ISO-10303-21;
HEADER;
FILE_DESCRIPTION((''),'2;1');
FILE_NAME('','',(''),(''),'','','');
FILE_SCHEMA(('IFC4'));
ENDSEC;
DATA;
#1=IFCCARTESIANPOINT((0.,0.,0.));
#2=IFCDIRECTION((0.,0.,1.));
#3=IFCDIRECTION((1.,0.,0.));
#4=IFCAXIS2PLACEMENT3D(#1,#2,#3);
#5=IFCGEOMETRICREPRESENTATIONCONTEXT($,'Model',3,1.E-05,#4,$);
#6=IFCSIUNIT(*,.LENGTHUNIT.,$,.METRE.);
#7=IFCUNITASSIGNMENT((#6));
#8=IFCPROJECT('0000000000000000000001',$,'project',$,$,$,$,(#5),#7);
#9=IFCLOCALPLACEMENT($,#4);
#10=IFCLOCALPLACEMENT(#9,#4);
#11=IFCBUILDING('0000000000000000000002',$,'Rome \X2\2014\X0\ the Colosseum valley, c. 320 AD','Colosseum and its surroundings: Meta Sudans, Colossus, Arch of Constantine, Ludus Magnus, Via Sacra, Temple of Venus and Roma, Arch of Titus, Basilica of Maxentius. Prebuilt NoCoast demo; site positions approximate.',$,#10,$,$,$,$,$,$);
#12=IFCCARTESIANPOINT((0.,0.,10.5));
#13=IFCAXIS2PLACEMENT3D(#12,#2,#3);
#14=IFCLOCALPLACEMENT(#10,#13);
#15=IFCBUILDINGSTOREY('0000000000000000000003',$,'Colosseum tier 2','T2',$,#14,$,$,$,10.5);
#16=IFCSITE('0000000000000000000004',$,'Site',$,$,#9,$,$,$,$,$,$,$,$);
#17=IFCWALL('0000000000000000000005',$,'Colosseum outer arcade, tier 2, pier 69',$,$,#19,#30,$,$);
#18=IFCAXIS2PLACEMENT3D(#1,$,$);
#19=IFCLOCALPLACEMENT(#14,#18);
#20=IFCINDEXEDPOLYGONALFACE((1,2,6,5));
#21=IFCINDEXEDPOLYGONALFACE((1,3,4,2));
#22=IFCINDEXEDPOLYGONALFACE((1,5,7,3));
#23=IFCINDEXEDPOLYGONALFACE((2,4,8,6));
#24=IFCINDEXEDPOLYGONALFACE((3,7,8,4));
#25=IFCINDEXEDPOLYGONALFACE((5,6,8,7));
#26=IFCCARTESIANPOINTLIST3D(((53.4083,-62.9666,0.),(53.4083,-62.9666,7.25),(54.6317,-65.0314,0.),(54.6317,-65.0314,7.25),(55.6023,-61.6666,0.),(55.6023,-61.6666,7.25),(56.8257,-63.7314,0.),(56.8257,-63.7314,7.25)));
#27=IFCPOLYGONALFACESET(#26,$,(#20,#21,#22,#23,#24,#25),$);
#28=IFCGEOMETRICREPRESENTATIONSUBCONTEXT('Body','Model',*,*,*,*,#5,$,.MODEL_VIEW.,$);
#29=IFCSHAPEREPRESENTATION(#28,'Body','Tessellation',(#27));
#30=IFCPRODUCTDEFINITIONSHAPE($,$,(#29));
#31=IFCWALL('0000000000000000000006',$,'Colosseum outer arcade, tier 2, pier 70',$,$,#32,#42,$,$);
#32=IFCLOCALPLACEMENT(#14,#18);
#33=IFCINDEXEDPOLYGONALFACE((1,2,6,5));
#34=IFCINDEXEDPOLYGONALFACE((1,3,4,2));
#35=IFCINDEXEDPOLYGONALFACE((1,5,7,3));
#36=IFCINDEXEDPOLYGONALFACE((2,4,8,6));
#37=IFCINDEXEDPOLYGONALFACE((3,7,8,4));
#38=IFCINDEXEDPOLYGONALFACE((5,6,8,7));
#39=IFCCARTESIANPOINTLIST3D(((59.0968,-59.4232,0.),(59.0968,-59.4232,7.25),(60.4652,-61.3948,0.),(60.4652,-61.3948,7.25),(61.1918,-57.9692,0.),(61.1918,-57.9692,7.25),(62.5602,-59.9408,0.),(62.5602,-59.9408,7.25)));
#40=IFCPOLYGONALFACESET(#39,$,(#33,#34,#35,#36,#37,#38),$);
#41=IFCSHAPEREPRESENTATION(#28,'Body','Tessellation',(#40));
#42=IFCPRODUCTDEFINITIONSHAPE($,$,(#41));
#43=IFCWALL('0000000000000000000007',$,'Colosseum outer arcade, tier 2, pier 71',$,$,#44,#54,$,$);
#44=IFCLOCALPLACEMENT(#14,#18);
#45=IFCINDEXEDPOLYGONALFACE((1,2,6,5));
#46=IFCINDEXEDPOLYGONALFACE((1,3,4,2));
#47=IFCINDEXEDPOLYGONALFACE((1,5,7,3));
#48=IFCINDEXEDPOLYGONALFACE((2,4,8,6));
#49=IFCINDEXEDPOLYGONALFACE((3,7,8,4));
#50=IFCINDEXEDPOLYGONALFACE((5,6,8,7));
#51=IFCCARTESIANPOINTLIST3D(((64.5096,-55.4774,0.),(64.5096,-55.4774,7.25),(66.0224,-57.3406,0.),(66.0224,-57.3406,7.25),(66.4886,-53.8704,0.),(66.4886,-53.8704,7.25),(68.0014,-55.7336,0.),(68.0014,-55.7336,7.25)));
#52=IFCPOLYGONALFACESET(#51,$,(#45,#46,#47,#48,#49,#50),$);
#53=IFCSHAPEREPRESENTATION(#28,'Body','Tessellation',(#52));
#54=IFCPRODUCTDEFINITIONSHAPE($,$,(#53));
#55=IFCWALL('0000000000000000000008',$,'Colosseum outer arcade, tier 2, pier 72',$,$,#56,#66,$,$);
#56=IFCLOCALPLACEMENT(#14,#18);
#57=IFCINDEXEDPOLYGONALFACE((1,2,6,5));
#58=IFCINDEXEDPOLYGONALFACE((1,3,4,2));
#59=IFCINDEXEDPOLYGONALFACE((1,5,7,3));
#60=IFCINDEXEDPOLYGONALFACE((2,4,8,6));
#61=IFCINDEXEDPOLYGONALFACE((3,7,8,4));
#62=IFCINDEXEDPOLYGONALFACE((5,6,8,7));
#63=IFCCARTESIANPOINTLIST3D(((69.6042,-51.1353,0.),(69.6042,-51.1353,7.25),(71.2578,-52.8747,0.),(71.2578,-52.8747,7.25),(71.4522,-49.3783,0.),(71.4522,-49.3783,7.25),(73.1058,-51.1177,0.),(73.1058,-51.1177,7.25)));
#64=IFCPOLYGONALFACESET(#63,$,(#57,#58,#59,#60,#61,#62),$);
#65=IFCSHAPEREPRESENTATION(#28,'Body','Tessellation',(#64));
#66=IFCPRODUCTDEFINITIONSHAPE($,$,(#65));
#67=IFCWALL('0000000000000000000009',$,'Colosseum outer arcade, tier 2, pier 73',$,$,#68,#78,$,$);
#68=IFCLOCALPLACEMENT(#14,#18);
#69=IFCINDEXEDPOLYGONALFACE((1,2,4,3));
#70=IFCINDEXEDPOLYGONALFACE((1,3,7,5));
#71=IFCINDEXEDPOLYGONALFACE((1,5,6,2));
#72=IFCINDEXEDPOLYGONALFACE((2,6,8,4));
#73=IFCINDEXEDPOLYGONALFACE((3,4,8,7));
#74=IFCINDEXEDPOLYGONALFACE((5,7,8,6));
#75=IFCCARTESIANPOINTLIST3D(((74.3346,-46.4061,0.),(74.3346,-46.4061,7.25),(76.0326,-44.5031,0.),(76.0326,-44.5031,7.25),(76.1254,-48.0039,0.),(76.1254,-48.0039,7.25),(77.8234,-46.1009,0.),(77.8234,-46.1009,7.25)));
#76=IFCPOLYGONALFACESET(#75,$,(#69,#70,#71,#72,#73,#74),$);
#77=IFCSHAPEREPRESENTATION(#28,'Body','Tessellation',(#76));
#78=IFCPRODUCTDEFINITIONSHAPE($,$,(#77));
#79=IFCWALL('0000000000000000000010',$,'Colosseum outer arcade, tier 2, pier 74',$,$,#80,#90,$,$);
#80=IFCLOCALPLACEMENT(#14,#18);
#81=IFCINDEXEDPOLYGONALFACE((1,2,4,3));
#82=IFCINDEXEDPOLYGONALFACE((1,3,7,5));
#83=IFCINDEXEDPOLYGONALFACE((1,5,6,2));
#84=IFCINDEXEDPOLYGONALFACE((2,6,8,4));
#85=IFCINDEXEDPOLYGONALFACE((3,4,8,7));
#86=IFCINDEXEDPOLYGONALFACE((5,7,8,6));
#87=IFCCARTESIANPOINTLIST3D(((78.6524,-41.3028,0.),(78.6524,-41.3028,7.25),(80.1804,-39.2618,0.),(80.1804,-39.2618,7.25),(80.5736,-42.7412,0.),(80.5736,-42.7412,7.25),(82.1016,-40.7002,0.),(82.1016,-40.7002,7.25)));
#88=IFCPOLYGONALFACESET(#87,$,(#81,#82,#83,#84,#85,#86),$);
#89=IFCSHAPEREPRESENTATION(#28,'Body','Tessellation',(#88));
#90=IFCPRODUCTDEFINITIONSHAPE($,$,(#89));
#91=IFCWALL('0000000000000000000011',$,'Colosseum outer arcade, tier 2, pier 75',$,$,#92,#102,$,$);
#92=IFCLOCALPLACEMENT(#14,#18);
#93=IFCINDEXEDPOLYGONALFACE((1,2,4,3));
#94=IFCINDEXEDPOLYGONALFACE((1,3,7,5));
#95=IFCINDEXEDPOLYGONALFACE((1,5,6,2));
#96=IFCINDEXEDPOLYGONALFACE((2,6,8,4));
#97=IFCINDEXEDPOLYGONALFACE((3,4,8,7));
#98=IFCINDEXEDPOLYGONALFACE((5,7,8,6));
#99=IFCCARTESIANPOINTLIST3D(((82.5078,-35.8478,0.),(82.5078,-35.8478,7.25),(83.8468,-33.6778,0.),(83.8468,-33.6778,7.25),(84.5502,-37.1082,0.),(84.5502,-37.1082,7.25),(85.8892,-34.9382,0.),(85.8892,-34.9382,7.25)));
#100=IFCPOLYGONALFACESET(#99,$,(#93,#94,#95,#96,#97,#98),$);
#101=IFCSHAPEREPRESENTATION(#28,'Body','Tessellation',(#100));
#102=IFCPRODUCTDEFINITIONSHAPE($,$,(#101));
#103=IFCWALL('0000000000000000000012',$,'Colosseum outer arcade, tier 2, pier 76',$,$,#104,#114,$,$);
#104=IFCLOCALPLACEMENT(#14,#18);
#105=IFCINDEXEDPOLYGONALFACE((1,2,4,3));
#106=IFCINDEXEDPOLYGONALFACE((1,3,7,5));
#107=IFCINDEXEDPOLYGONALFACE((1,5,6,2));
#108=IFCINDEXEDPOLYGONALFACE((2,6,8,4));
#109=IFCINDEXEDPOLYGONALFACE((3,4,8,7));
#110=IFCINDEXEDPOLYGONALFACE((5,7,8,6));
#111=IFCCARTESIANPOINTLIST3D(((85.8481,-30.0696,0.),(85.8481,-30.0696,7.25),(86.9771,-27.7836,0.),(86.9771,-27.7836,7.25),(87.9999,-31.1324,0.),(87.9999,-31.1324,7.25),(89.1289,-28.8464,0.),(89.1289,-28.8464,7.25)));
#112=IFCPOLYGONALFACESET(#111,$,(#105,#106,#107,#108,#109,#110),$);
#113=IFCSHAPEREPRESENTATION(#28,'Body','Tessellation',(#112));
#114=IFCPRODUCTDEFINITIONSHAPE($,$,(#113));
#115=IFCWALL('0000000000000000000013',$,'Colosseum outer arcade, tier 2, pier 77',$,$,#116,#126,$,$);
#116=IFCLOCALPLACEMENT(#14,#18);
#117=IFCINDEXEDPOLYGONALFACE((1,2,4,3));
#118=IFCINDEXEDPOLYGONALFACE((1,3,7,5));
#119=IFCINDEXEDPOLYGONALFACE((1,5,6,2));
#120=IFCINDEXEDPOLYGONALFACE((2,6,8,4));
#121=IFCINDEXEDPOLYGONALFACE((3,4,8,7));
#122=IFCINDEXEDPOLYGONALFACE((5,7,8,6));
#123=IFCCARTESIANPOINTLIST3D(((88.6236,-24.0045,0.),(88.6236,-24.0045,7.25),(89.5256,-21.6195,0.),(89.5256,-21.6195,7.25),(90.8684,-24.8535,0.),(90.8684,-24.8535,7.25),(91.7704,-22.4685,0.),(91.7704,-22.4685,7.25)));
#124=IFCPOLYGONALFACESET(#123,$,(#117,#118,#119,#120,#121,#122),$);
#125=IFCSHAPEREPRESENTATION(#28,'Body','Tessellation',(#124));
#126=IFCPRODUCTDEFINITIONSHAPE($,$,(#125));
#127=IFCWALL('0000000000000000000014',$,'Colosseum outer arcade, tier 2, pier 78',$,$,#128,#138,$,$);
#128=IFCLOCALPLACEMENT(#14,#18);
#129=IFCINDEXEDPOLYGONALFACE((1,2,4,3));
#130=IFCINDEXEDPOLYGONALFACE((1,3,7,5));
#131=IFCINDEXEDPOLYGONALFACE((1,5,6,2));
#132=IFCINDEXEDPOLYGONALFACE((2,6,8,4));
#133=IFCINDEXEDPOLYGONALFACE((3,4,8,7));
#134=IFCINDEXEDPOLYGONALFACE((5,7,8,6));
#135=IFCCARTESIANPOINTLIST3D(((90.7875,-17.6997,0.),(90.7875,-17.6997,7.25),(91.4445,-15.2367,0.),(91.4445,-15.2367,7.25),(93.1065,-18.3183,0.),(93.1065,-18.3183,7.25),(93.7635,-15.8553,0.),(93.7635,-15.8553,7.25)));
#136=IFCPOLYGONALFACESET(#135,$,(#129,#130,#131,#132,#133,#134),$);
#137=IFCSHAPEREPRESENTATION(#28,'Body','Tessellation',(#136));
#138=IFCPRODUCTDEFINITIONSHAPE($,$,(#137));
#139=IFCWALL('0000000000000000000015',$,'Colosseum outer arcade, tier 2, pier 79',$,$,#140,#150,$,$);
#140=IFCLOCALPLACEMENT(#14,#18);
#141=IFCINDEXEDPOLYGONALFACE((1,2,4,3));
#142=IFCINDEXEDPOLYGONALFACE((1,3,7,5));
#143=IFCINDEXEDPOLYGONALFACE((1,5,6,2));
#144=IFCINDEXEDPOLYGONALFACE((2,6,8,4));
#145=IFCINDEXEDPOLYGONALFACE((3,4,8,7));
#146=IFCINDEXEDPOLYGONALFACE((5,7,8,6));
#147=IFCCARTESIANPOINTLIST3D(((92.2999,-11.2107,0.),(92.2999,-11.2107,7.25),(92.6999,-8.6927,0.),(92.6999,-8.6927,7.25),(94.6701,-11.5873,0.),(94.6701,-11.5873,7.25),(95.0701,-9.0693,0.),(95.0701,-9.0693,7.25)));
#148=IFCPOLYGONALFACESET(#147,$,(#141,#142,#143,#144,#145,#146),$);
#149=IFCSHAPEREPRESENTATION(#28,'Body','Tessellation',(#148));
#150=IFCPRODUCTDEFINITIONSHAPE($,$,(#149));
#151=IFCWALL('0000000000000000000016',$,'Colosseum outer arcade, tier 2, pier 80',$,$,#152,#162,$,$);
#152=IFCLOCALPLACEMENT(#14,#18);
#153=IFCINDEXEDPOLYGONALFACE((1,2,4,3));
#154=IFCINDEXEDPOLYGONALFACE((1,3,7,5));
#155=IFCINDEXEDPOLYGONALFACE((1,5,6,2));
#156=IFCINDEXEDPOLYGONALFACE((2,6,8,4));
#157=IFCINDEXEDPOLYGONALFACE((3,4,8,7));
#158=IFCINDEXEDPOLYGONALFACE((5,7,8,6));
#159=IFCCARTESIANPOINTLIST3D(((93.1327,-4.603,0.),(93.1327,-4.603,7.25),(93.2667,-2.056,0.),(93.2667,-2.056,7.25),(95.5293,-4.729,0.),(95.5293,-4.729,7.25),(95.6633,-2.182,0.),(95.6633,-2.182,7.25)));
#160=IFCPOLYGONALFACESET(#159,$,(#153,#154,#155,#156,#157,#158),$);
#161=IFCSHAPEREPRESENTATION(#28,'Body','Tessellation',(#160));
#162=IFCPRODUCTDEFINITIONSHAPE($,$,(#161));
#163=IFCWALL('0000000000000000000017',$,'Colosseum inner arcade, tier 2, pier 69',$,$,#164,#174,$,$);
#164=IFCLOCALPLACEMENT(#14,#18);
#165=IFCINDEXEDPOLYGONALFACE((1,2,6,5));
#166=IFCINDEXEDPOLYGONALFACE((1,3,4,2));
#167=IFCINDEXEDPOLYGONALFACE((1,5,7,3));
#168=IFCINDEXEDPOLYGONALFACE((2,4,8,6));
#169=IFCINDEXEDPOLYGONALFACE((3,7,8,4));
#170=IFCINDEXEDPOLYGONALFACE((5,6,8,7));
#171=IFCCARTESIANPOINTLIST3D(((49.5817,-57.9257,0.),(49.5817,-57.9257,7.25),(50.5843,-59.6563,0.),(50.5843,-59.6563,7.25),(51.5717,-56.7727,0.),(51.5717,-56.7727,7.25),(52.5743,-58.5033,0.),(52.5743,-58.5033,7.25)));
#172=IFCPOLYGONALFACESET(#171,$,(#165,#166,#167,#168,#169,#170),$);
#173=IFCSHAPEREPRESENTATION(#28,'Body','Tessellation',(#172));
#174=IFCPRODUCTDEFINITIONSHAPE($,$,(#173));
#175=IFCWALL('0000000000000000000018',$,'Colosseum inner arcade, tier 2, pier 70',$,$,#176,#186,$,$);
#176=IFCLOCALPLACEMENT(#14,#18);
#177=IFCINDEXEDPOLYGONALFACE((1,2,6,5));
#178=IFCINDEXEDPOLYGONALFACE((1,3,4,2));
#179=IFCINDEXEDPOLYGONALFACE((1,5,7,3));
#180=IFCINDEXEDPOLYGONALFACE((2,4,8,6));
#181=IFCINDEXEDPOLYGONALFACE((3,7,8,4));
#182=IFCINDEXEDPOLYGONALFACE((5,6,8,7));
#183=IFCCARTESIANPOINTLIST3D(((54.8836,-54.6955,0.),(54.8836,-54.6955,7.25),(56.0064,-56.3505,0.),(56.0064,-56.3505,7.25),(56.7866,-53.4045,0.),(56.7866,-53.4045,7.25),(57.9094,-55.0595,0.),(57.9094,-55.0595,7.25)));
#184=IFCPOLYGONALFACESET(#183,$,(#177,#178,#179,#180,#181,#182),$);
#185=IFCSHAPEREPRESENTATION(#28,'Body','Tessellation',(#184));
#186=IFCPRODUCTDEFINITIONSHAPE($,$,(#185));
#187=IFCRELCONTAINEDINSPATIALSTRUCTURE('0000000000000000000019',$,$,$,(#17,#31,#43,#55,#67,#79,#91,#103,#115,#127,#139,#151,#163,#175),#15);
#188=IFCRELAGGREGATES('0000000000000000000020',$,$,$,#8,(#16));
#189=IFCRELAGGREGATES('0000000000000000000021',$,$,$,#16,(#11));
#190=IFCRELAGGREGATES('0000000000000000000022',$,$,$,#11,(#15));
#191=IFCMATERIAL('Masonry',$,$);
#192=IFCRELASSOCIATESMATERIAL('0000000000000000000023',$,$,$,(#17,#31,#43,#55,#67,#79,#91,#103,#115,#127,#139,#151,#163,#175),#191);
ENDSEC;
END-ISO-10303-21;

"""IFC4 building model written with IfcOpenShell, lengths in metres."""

from ifc_helpers import new_model, si_unit, frame, origin_with_axes, place, context, subcontext, project, spatial, indexed_curve, outline, extrude, material, element, save


model = new_model("IFC4")

# Units and contexts
model_context = context("Model", 3, precision=1e-05, world=origin_with_axes())
body_context = subcontext(model_context, "Body", "Model", "MODEL_VIEW")
ifc_project = project(units=[si_unit("LENGTHUNIT", "METRE")], contexts=[model_context])

# Site, building, storey
site_placement = place(None, origin_with_axes())
site = spatial("IfcSite", under=ifc_project, at=site_placement, Name="Site")
building_placement = place(site_placement, origin_with_axes())
building = spatial("IfcBuilding", under=site, at=building_placement, Name="Rome — the Colosseum valley, c. 320 AD", Description="Colosseum and its surroundings: Meta Sudans, Colossus, Arch of Constantine, Ludus Magnus, Via Sacra, Temple of Venus and Roma, Arch of Titus, Basilica of Maxentius. Prebuilt NoCoast demo; site positions approximate.")
storey_placement = place(building_placement, frame((0.0, 0.0, 10.5), z_axis=(0.0, 0.0, 1.0), x_axis=(1.0, 0.0, 0.0)))
storey = spatial("IfcBuildingStorey", under=building, at=storey_placement, Name="Colosseum tier 2", Description="T2", Elevation=10.5)

# Walls
ifc_material = material(Name="Masonry")
wall_1_placement = place(storey_placement, frame((54.02, -63.999, 0.0), z_axis=(0.0, 0.0, 1.0), x_axis=(0.860317, 0.509759, 0.0)))
element("IfcWall", 1, at=wall_1_placement, inside=storey, material=ifc_material, Name="Colosseum outer arcade, tier 2, pier 69", context=body_context, shape_type="SweptSolid", body=[
    extrude(outline(indexed_curve([(0.0, 0.0), (0.0, 2.4), (2.5502, 2.4), (2.5502, 0.0), (0.0, 0.0)], self_intersect=False)), frame((0.0, -1.2, 0.0), z_axis=(0.0, 0.0, 1.0), x_axis=(1.0, 0.0, 0.0)), (0.0, 0.0, 1.0), 7.25),
])
wall_2_placement = place(storey_placement, frame((59.781, -60.409, 0.0), z_axis=(0.0, 0.0, 1.0), x_axis=(0.821528, 0.570168, 0.0)))
element("IfcWall", 2, at=wall_2_placement, inside=storey, material=ifc_material, Name="Colosseum outer arcade, tier 2, pier 70", context=body_context, shape_type="SweptSolid", body=[
    extrude(outline(indexed_curve([(0.0, 0.0), (0.0, 2.4), (2.5501, 2.4), (2.5501, 0.0), (0.0, 0.0)], self_intersect=False)), frame((0.0, -1.2, 0.0), z_axis=(0.0, 0.0, 1.0), x_axis=(1.0, 0.0, 0.0)), (0.0, 0.0, 1.0), 7.25),
])
wall_3_placement = place(storey_placement, frame((65.266, -56.409, 0.0), z_axis=(0.0, 0.0, 1.0), x_axis=(0.776294, 0.630371, 0.0)))
element("IfcWall", 3, at=wall_3_placement, inside=storey, material=ifc_material, Name="Colosseum outer arcade, tier 2, pier 71", context=body_context, shape_type="SweptSolid", body=[
    extrude(outline(indexed_curve([(0.0, 0.0), (0.0, 2.4), (2.5493, 2.4), (2.5493, 0.0), (0.0, 0.0)], self_intersect=False)), frame((0.0, -1.2, 0.0), z_axis=(0.0, 0.0, 1.0), x_axis=(1.0, 0.0, 0.0)), (0.0, 0.0, 1.0), 7.25),
])
wall_4_placement = place(storey_placement, frame((70.431, -52.005, 0.0), z_axis=(0.0, 0.0, 1.0), x_axis=(0.724725, 0.689038, 0.0)))
element("IfcWall", 4, at=wall_4_placement, inside=storey, material=ifc_material, Name="Colosseum outer arcade, tier 2, pier 72", context=body_context, shape_type="SweptSolid", body=[
    extrude(outline(indexed_curve([(0.0, 0.0), (0.0, 2.4), (2.5499, 2.4), (2.5499, 0.0), (0.0, 0.0)], self_intersect=False)), frame((0.0, -1.2, 0.0), z_axis=(0.0, 0.0, 1.0), x_axis=(1.0, 0.0, 0.0)), (0.0, 0.0, 1.0), 7.25),
])
wall_5_placement = place(storey_placement, frame((75.23, -47.205, 0.0), z_axis=(0.0, 0.0, 1.0), x_axis=(0.665774, 0.746153, 0.0)))
element("IfcWall", 5, at=wall_5_placement, inside=storey, material=ifc_material, Name="Colosseum outer arcade, tier 2, pier 73", context=body_context, shape_type="SweptSolid", body=[
    extrude(outline(indexed_curve([(0.0, 0.0), (0.0, 2.4), (2.5504, 2.4), (2.5504, 0.0), (0.0, 0.0)], self_intersect=False)), frame((0.0, -1.2, 0.0), z_axis=(0.0, 0.0, 1.0), x_axis=(1.0, 0.0, 0.0)), (0.0, 0.0, 1.0), 7.25),
])
wall_6_placement = place(storey_placement, frame((79.613, -42.022, 0.0), z_axis=(0.0, 0.0, 1.0), x_axis=(0.599309, 0.800517, 0.0)))
element("IfcWall", 6, at=wall_6_placement, inside=storey, material=ifc_material, Name="Colosseum outer arcade, tier 2, pier 74", context=body_context, shape_type="SweptSolid", body=[
    extrude(outline(indexed_curve([(0.0, 0.0), (0.0, 2.4), (2.5496, 2.4), (2.5496, 0.0), (0.0, 0.0)], self_intersect=False)), frame((0.0, -1.2, 0.0), z_axis=(0.0, 0.0, 1.0), x_axis=(1.0, 0.0, 0.0)), (0.0, 0.0, 1.0), 7.25),
])
wall_7_placement = place(storey_placement, frame((83.529, -36.478, 0.0), z_axis=(0.0, 0.0, 1.0), x_axis=(0.525125, 0.851025, 0.0)))
element("IfcWall", 7, at=wall_7_placement, inside=storey, material=ifc_material, Name="Colosseum outer arcade, tier 2, pier 75", context=body_context, shape_type="SweptSolid", body=[
    extrude(outline(indexed_curve([(0.0, 0.0), (0.0, 2.4), (2.5499, 2.4), (2.5499, 0.0), (0.0, 0.0)], self_intersect=False)), frame((0.0, -1.2, 0.0), z_axis=(0.0, 0.0, 1.0), x_axis=(1.0, 0.0, 0.0)), (0.0, 0.0, 1.0), 7.25),
])
wall_8_placement = place(storey_placement, frame((86.924, -30.601, 0.0), z_axis=(0.0, 0.0, 1.0), x_axis=(0.442815, 0.896613, 0.0)))
element("IfcWall", 8, at=wall_8_placement, inside=storey, material=ifc_material, Name="Colosseum outer arcade, tier 2, pier 76", context=body_context, shape_type="SweptSolid", body=[
    extrude(outline(indexed_curve([(0.0, 0.0), (0.0, 2.4), (2.5496, 2.4), (2.5496, 0.0), (0.0, 0.0)], self_intersect=False)), frame((0.0, -1.2, 0.0), z_axis=(0.0, 0.0, 1.0), x_axis=(1.0, 0.0, 0.0)), (0.0, 0.0, 1.0), 7.25),
])
wall_9_placement = place(storey_placement, frame((89.746, -24.429, 0.0), z_axis=(0.0, 0.0, 1.0), x_axis=(0.353744, 0.935342, 0.0)))
element("IfcWall", 9, at=wall_9_placement, inside=storey, material=ifc_material, Name="Colosseum outer arcade, tier 2, pier 77", context=body_context, shape_type="SweptSolid", body=[
    extrude(outline(indexed_curve([(0.0, 0.0), (0.0, 2.4), (2.5499, 2.4), (2.5499, 0.0), (0.0, 0.0)], self_intersect=False)), frame((0.0, -1.2, 0.0), z_axis=(0.0, 0.0, 1.0), x_axis=(1.0, 0.0, 0.0)), (0.0, 0.0, 1.0), 7.25),
])
wall_10_placement = place(storey_placement, frame((91.947, -18.009, 0.0), z_axis=(0.0, 0.0, 1.0), x_axis=(0.257736, 0.966215, 0.0)))
element("IfcWall", 10, at=wall_10_placement, inside=storey, material=ifc_material, Name="Colosseum outer arcade, tier 2, pier 78", context=body_context, shape_type="SweptSolid", body=[
    extrude(outline(indexed_curve([(0.0, 0.0), (0.0, 2.4), (2.5491, 2.4), (2.5491, 0.0), (0.0, 0.0)], self_intersect=False)), frame((0.0, -1.2, 0.0), z_axis=(0.0, 0.0, 1.0), x_axis=(1.0, 0.0, 0.0)), (0.0, 0.0, 1.0), 7.25),
])
wall_11_placement = place(storey_placement, frame((93.485, -11.399, 0.0), z_axis=(0.0, 0.0, 1.0), x_axis=(0.156889, 0.987616, 0.0)))
element("IfcWall", 11, at=wall_11_placement, inside=storey, material=ifc_material, Name="Colosseum outer arcade, tier 2, pier 79", context=body_context, shape_type="SweptSolid", body=[
    extrude(outline(indexed_curve([(0.0, 0.0), (0.0, 2.4), (2.5496, 2.4), (2.5496, 0.0), (0.0, 0.0)], self_intersect=False)), frame((0.0, -1.2, 0.0), z_axis=(0.0, 0.0, 1.0), x_axis=(1.0, 0.0, 0.0)), (0.0, 0.0, 1.0), 7.25),
])
wall_12_placement = place(storey_placement, frame((94.331, -4.666, 0.0), z_axis=(0.0, 0.0, 1.0), x_axis=(0.052538, 0.998619, 0.0)))
element("IfcWall", 12, at=wall_12_placement, inside=storey, material=ifc_material, Name="Colosseum outer arcade, tier 2, pier 80", context=body_context, shape_type="SweptSolid", body=[
    extrude(outline(indexed_curve([(0.0, 0.0), (0.0, 2.4), (2.5505, 2.4), (2.5505, 0.0), (0.0, 0.0)], self_intersect=False)), frame((0.0, -1.2, 0.0), z_axis=(0.0, 0.0, 1.0), x_axis=(1.0, 0.0, 0.0)), (0.0, 0.0, 1.0), 7.25),
])
wall_13_placement = place(storey_placement, frame((50.083, -58.791, 0.0), z_axis=(0.0, 0.0, 1.0), x_axis=(0.865258, 0.501328, 0.0)))
element("IfcWall", 13, at=wall_13_placement, inside=storey, material=ifc_material, Name="Colosseum inner arcade, tier 2, pier 69", context=body_context, shape_type="SweptSolid", body=[
    extrude(outline(indexed_curve([(0.0, 0.0), (0.0, 2.0), (2.2999, 2.0), (2.2999, 0.0), (0.0, 0.0)], self_intersect=False)), frame((0.0, -1.0, 0.0), z_axis=(0.0, 0.0, 1.0), x_axis=(1.0, 0.0, 0.0)), (0.0, 0.0, 1.0), 7.25),
])
wall_14_placement = place(storey_placement, frame((55.445, -55.523, 0.0), z_axis=(0.0, 0.0, 1.0), x_axis=(0.827541, 0.561406, 0.0)))
element("IfcWall", 14, at=wall_14_placement, inside=storey, material=ifc_material, Name="Colosseum inner arcade, tier 2, pier 70", context=body_context, shape_type="SweptSolid", body=[
    extrude(outline(indexed_curve([(0.0, 0.0), (0.0, 2.0), (2.2996, 2.0), (2.2996, 0.0), (0.0, 0.0)], self_intersect=False)), frame((0.0, -1.0, 0.0), z_axis=(0.0, 0.0, 1.0), x_axis=(1.0, 0.0, 0.0)), (0.0, 0.0, 1.0), 7.25),
])

save(model, "model.ifc")
